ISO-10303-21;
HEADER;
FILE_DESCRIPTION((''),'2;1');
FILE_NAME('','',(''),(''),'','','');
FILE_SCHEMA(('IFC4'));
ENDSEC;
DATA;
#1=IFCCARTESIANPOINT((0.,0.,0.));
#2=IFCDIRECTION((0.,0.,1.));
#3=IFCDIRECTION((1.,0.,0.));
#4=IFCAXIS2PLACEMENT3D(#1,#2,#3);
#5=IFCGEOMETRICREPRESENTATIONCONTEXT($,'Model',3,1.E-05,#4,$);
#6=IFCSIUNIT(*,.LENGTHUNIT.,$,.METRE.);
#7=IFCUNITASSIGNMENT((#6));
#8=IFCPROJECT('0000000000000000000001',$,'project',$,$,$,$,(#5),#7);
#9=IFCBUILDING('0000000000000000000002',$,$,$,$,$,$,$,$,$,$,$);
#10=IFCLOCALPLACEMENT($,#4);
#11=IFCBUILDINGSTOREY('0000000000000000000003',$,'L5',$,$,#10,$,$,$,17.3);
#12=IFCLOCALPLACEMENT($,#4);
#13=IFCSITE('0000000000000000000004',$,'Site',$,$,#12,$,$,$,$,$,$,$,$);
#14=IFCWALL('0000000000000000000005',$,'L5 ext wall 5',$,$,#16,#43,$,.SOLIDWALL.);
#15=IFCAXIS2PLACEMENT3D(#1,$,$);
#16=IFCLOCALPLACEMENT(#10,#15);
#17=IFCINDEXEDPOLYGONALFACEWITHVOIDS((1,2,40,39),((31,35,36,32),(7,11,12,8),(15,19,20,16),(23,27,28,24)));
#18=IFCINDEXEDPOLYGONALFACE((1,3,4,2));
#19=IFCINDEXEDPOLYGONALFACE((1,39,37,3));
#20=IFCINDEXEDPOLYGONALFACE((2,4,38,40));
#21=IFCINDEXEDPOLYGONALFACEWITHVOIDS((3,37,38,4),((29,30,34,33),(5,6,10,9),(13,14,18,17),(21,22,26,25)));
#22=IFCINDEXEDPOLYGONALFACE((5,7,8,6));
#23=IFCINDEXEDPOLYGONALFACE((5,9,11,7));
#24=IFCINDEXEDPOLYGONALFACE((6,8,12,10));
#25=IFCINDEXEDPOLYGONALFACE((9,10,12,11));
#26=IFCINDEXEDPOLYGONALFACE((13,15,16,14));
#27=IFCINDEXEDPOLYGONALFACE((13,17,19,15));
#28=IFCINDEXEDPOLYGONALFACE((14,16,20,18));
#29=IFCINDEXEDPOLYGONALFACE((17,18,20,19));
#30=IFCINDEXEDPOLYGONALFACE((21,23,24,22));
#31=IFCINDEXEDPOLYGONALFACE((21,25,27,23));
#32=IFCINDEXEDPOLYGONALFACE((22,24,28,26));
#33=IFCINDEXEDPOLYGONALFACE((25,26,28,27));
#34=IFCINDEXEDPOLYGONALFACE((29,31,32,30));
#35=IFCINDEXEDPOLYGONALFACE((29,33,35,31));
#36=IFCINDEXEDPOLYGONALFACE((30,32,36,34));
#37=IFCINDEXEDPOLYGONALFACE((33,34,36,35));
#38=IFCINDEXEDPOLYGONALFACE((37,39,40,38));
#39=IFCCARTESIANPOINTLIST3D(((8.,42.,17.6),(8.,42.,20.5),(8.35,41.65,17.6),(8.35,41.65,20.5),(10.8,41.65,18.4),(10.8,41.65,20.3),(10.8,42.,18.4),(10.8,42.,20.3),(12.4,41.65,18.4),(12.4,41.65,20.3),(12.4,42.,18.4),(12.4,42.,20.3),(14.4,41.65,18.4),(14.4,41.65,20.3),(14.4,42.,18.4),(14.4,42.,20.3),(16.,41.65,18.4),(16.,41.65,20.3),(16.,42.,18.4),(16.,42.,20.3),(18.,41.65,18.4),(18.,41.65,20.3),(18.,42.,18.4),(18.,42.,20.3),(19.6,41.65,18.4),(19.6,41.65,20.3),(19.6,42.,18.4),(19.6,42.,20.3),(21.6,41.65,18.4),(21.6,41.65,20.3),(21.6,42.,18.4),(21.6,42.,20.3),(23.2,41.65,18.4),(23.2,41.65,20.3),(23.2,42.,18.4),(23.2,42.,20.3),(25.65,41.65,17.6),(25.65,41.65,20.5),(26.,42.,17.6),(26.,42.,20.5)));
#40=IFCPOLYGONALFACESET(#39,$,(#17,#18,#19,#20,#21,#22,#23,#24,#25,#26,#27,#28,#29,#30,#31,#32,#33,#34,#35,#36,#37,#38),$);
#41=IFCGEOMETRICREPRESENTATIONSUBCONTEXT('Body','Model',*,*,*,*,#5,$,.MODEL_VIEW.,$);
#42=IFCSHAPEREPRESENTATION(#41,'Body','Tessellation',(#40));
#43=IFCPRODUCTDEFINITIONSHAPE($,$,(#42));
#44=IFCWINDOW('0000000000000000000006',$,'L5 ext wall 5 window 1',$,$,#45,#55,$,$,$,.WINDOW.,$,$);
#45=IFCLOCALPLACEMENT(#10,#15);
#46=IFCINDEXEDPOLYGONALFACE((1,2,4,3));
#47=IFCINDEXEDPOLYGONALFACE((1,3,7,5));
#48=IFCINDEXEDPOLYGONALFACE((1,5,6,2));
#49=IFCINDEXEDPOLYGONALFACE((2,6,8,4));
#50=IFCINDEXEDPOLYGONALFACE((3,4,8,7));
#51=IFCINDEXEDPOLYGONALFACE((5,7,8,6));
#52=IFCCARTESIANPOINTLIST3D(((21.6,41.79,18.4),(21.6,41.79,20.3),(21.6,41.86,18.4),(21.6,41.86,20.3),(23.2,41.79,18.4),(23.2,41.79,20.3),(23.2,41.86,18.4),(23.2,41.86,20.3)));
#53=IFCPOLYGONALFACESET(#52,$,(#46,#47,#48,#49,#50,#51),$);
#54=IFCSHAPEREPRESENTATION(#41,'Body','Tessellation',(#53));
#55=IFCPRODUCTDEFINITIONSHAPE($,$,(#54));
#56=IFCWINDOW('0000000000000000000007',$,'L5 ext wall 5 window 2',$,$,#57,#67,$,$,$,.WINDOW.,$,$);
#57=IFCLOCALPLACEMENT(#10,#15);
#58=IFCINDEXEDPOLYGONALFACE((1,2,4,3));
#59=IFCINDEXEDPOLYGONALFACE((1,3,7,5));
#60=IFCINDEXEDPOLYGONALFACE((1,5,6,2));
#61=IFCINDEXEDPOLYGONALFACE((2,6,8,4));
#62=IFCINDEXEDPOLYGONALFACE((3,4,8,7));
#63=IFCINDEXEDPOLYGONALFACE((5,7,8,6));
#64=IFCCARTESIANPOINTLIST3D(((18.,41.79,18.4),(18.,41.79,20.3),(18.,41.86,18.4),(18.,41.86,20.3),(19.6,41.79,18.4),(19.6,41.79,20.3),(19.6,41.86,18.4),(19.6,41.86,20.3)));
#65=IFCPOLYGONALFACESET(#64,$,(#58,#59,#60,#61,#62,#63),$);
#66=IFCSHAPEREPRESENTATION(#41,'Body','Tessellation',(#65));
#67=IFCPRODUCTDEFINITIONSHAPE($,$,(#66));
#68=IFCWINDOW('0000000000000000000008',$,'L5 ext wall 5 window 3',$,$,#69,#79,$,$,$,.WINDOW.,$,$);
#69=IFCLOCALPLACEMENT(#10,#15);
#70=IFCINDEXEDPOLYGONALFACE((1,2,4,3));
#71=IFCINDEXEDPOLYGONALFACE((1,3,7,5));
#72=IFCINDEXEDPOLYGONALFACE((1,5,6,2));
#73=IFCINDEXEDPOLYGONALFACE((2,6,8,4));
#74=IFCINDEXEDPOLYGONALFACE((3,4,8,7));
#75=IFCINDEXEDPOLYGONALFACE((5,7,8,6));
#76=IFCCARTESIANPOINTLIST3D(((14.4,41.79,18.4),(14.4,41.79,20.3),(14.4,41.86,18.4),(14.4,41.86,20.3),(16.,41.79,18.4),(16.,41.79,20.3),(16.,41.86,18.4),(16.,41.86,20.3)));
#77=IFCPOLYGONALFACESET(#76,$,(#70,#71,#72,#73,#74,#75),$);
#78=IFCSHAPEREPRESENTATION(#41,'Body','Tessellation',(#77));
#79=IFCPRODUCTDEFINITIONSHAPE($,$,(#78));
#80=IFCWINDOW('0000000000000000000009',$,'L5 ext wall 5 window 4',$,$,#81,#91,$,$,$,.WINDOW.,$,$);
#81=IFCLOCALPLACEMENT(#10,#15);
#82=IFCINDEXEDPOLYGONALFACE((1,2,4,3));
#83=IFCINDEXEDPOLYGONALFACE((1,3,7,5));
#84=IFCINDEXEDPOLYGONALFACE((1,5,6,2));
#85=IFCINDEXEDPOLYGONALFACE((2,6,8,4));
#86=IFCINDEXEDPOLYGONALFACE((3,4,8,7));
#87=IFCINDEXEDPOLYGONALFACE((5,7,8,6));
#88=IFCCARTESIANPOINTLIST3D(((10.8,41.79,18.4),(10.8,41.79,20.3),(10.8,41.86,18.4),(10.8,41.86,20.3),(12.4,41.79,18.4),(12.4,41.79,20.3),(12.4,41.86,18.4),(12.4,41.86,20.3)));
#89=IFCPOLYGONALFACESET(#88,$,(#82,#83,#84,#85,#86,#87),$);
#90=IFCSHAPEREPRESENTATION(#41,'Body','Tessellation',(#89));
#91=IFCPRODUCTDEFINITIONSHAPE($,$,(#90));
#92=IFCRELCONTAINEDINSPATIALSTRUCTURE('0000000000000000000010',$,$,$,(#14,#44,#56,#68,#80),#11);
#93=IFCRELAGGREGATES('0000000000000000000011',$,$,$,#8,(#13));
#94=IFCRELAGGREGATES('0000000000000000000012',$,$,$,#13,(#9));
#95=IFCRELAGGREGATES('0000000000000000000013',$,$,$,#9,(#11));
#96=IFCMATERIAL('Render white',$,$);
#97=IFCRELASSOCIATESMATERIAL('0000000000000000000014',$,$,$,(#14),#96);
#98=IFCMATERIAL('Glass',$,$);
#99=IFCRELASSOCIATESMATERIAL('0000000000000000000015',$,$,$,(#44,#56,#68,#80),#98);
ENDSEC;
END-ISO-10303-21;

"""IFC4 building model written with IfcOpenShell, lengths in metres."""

from ifc_helpers import new_model, si_unit, frame, origin_with_axes, place, context, subcontext, project, spatial, polyline, outline, extrude, material, element, fill, save


model = new_model("IFC4")

# Units and contexts
model_context = context("Model", 3, precision=1e-05, world=origin_with_axes())
body_context = subcontext(model_context, "Body", "Model", "MODEL_VIEW")
ifc_project = project(units=[si_unit("LENGTHUNIT", "METRE")], contexts=[model_context])

# Site, building, storey
site_placement = place(None, origin_with_axes())
site = spatial("IfcSite", under=ifc_project, at=site_placement, Name="Site")
building = spatial("IfcBuilding", under=site)
storey_placement = place(None, origin_with_axes())
storey = spatial("IfcBuildingStorey", under=building, at=storey_placement, Name="L5", Elevation=17.3)

# Wall, openings, windows
ifc_material_1 = material(Name="Render white")
wall_1_placement = place(storey_placement, origin_with_axes())
wall_1 = element("IfcWall", 1, at=wall_1_placement, inside=storey, material=ifc_material_1, Name="L5 ext wall 5", PredefinedType="SOLIDWALL", context=body_context, shape_type="SweptSolid", body=[
    extrude(outline(polyline([(26.0, 42.0), (8.0, 42.0), (8.35, 41.65), (25.65, 41.65), (26.0, 42.0)])), frame((0.0, 0.0, 17.6), z_axis=(0.0, 0.0, 1.0), x_axis=(1.0, 0.0, 0.0)), (0.0, 0.0, 1.0), 2.9),
])
opening_1_placement = place(wall_1_placement, origin_with_axes())
opening_1 = element("IfcOpeningElement", 2, at=opening_1_placement, cuts=wall_1, context=body_context, shape_type="SweptSolid", body=[
    extrude(outline(polyline([(23.2, 42.05), (21.6, 42.05), (21.6, 41.6), (23.2, 41.6), (23.2, 42.05)])), frame((0.0, 0.0, 18.4), z_axis=(0.0, 0.0, 1.0), x_axis=(1.0, 0.0, 0.0)), (0.0, 0.0, 1.0), 1.9),
])
opening_2_placement = place(wall_1_placement, origin_with_axes())
opening_2 = element("IfcOpeningElement", 3, at=opening_2_placement, cuts=wall_1, context=body_context, shape_type="SweptSolid", body=[
    extrude(outline(polyline([(19.6, 42.05), (18.0, 42.05), (18.0, 41.6), (19.6, 41.6), (19.6, 42.05)])), frame((0.0, 0.0, 18.4), z_axis=(0.0, 0.0, 1.0), x_axis=(1.0, 0.0, 0.0)), (0.0, 0.0, 1.0), 1.9),
])
opening_3_placement = place(wall_1_placement, origin_with_axes())
opening_3 = element("IfcOpeningElement", 4, at=opening_3_placement, cuts=wall_1, context=body_context, shape_type="SweptSolid", body=[
    extrude(outline(polyline([(16.0, 42.05), (14.4, 42.05), (14.4, 41.6), (16.0, 41.6), (16.0, 42.05)])), frame((0.0, 0.0, 18.4), z_axis=(0.0, 0.0, 1.0), x_axis=(1.0, 0.0, 0.0)), (0.0, 0.0, 1.0), 1.9),
])
opening_4_placement = place(wall_1_placement, origin_with_axes())
opening_4 = element("IfcOpeningElement", 5, at=opening_4_placement, cuts=wall_1, context=body_context, shape_type="SweptSolid", body=[
    extrude(outline(polyline([(12.4, 42.05), (10.8, 42.05), (10.8, 41.6), (12.4, 41.6), (12.4, 42.05)])), frame((0.0, 0.0, 18.4), z_axis=(0.0, 0.0, 1.0), x_axis=(1.0, 0.0, 0.0)), (0.0, 0.0, 1.0), 1.9),
])
ifc_material_2 = material(Name="Glass")
window_1_placement = place(storey_placement, origin_with_axes())
window_1 = element("IfcWindow", 6, at=window_1_placement, inside=storey, material=ifc_material_2, Name="L5 ext wall 5 window 1", PredefinedType="WINDOW", context=body_context, shape_type="SweptSolid", body=[
    extrude(outline(polyline([(23.2, 41.86), (21.6, 41.86), (21.6, 41.79), (23.2, 41.79), (23.2, 41.86)])), frame((0.0, 0.0, 18.4), z_axis=(0.0, 0.0, 1.0), x_axis=(1.0, 0.0, 0.0)), (0.0, 0.0, 1.0), 1.9),
])
fill(opening_1, window_1)
window_2_placement = place(storey_placement, origin_with_axes())
window_2 = element("IfcWindow", 7, at=window_2_placement, inside=storey, material=ifc_material_2, Name="L5 ext wall 5 window 2", PredefinedType="WINDOW", context=body_context, shape_type="SweptSolid", body=[
    extrude(outline(polyline([(19.6, 41.86), (18.0, 41.86), (18.0, 41.79), (19.6, 41.79), (19.6, 41.86)])), frame((0.0, 0.0, 18.4), z_axis=(0.0, 0.0, 1.0), x_axis=(1.0, 0.0, 0.0)), (0.0, 0.0, 1.0), 1.9),
])
fill(opening_2, window_2)
window_3_placement = place(storey_placement, origin_with_axes())
window_3 = element("IfcWindow", 8, at=window_3_placement, inside=storey, material=ifc_material_2, Name="L5 ext wall 5 window 3", PredefinedType="WINDOW", context=body_context, shape_type="SweptSolid", body=[
    extrude(outline(polyline([(16.0, 41.86), (14.4, 41.86), (14.4, 41.79), (16.0, 41.79), (16.0, 41.86)])), frame((0.0, 0.0, 18.4), z_axis=(0.0, 0.0, 1.0), x_axis=(1.0, 0.0, 0.0)), (0.0, 0.0, 1.0), 1.9),
])
fill(opening_3, window_3)
window_4_placement = place(storey_placement, origin_with_axes())
window_4 = element("IfcWindow", 9, at=window_4_placement, inside=storey, material=ifc_material_2, Name="L5 ext wall 5 window 4", PredefinedType="WINDOW", context=body_context, shape_type="SweptSolid", body=[
    extrude(outline(polyline([(12.4, 41.86), (10.8, 41.86), (10.8, 41.79), (12.4, 41.79), (12.4, 41.86)])), frame((0.0, 0.0, 18.4), z_axis=(0.0, 0.0, 1.0), x_axis=(1.0, 0.0, 0.0)), (0.0, 0.0, 1.0), 1.9),
])
fill(opening_4, window_4)

save(model, "model.ifc")
